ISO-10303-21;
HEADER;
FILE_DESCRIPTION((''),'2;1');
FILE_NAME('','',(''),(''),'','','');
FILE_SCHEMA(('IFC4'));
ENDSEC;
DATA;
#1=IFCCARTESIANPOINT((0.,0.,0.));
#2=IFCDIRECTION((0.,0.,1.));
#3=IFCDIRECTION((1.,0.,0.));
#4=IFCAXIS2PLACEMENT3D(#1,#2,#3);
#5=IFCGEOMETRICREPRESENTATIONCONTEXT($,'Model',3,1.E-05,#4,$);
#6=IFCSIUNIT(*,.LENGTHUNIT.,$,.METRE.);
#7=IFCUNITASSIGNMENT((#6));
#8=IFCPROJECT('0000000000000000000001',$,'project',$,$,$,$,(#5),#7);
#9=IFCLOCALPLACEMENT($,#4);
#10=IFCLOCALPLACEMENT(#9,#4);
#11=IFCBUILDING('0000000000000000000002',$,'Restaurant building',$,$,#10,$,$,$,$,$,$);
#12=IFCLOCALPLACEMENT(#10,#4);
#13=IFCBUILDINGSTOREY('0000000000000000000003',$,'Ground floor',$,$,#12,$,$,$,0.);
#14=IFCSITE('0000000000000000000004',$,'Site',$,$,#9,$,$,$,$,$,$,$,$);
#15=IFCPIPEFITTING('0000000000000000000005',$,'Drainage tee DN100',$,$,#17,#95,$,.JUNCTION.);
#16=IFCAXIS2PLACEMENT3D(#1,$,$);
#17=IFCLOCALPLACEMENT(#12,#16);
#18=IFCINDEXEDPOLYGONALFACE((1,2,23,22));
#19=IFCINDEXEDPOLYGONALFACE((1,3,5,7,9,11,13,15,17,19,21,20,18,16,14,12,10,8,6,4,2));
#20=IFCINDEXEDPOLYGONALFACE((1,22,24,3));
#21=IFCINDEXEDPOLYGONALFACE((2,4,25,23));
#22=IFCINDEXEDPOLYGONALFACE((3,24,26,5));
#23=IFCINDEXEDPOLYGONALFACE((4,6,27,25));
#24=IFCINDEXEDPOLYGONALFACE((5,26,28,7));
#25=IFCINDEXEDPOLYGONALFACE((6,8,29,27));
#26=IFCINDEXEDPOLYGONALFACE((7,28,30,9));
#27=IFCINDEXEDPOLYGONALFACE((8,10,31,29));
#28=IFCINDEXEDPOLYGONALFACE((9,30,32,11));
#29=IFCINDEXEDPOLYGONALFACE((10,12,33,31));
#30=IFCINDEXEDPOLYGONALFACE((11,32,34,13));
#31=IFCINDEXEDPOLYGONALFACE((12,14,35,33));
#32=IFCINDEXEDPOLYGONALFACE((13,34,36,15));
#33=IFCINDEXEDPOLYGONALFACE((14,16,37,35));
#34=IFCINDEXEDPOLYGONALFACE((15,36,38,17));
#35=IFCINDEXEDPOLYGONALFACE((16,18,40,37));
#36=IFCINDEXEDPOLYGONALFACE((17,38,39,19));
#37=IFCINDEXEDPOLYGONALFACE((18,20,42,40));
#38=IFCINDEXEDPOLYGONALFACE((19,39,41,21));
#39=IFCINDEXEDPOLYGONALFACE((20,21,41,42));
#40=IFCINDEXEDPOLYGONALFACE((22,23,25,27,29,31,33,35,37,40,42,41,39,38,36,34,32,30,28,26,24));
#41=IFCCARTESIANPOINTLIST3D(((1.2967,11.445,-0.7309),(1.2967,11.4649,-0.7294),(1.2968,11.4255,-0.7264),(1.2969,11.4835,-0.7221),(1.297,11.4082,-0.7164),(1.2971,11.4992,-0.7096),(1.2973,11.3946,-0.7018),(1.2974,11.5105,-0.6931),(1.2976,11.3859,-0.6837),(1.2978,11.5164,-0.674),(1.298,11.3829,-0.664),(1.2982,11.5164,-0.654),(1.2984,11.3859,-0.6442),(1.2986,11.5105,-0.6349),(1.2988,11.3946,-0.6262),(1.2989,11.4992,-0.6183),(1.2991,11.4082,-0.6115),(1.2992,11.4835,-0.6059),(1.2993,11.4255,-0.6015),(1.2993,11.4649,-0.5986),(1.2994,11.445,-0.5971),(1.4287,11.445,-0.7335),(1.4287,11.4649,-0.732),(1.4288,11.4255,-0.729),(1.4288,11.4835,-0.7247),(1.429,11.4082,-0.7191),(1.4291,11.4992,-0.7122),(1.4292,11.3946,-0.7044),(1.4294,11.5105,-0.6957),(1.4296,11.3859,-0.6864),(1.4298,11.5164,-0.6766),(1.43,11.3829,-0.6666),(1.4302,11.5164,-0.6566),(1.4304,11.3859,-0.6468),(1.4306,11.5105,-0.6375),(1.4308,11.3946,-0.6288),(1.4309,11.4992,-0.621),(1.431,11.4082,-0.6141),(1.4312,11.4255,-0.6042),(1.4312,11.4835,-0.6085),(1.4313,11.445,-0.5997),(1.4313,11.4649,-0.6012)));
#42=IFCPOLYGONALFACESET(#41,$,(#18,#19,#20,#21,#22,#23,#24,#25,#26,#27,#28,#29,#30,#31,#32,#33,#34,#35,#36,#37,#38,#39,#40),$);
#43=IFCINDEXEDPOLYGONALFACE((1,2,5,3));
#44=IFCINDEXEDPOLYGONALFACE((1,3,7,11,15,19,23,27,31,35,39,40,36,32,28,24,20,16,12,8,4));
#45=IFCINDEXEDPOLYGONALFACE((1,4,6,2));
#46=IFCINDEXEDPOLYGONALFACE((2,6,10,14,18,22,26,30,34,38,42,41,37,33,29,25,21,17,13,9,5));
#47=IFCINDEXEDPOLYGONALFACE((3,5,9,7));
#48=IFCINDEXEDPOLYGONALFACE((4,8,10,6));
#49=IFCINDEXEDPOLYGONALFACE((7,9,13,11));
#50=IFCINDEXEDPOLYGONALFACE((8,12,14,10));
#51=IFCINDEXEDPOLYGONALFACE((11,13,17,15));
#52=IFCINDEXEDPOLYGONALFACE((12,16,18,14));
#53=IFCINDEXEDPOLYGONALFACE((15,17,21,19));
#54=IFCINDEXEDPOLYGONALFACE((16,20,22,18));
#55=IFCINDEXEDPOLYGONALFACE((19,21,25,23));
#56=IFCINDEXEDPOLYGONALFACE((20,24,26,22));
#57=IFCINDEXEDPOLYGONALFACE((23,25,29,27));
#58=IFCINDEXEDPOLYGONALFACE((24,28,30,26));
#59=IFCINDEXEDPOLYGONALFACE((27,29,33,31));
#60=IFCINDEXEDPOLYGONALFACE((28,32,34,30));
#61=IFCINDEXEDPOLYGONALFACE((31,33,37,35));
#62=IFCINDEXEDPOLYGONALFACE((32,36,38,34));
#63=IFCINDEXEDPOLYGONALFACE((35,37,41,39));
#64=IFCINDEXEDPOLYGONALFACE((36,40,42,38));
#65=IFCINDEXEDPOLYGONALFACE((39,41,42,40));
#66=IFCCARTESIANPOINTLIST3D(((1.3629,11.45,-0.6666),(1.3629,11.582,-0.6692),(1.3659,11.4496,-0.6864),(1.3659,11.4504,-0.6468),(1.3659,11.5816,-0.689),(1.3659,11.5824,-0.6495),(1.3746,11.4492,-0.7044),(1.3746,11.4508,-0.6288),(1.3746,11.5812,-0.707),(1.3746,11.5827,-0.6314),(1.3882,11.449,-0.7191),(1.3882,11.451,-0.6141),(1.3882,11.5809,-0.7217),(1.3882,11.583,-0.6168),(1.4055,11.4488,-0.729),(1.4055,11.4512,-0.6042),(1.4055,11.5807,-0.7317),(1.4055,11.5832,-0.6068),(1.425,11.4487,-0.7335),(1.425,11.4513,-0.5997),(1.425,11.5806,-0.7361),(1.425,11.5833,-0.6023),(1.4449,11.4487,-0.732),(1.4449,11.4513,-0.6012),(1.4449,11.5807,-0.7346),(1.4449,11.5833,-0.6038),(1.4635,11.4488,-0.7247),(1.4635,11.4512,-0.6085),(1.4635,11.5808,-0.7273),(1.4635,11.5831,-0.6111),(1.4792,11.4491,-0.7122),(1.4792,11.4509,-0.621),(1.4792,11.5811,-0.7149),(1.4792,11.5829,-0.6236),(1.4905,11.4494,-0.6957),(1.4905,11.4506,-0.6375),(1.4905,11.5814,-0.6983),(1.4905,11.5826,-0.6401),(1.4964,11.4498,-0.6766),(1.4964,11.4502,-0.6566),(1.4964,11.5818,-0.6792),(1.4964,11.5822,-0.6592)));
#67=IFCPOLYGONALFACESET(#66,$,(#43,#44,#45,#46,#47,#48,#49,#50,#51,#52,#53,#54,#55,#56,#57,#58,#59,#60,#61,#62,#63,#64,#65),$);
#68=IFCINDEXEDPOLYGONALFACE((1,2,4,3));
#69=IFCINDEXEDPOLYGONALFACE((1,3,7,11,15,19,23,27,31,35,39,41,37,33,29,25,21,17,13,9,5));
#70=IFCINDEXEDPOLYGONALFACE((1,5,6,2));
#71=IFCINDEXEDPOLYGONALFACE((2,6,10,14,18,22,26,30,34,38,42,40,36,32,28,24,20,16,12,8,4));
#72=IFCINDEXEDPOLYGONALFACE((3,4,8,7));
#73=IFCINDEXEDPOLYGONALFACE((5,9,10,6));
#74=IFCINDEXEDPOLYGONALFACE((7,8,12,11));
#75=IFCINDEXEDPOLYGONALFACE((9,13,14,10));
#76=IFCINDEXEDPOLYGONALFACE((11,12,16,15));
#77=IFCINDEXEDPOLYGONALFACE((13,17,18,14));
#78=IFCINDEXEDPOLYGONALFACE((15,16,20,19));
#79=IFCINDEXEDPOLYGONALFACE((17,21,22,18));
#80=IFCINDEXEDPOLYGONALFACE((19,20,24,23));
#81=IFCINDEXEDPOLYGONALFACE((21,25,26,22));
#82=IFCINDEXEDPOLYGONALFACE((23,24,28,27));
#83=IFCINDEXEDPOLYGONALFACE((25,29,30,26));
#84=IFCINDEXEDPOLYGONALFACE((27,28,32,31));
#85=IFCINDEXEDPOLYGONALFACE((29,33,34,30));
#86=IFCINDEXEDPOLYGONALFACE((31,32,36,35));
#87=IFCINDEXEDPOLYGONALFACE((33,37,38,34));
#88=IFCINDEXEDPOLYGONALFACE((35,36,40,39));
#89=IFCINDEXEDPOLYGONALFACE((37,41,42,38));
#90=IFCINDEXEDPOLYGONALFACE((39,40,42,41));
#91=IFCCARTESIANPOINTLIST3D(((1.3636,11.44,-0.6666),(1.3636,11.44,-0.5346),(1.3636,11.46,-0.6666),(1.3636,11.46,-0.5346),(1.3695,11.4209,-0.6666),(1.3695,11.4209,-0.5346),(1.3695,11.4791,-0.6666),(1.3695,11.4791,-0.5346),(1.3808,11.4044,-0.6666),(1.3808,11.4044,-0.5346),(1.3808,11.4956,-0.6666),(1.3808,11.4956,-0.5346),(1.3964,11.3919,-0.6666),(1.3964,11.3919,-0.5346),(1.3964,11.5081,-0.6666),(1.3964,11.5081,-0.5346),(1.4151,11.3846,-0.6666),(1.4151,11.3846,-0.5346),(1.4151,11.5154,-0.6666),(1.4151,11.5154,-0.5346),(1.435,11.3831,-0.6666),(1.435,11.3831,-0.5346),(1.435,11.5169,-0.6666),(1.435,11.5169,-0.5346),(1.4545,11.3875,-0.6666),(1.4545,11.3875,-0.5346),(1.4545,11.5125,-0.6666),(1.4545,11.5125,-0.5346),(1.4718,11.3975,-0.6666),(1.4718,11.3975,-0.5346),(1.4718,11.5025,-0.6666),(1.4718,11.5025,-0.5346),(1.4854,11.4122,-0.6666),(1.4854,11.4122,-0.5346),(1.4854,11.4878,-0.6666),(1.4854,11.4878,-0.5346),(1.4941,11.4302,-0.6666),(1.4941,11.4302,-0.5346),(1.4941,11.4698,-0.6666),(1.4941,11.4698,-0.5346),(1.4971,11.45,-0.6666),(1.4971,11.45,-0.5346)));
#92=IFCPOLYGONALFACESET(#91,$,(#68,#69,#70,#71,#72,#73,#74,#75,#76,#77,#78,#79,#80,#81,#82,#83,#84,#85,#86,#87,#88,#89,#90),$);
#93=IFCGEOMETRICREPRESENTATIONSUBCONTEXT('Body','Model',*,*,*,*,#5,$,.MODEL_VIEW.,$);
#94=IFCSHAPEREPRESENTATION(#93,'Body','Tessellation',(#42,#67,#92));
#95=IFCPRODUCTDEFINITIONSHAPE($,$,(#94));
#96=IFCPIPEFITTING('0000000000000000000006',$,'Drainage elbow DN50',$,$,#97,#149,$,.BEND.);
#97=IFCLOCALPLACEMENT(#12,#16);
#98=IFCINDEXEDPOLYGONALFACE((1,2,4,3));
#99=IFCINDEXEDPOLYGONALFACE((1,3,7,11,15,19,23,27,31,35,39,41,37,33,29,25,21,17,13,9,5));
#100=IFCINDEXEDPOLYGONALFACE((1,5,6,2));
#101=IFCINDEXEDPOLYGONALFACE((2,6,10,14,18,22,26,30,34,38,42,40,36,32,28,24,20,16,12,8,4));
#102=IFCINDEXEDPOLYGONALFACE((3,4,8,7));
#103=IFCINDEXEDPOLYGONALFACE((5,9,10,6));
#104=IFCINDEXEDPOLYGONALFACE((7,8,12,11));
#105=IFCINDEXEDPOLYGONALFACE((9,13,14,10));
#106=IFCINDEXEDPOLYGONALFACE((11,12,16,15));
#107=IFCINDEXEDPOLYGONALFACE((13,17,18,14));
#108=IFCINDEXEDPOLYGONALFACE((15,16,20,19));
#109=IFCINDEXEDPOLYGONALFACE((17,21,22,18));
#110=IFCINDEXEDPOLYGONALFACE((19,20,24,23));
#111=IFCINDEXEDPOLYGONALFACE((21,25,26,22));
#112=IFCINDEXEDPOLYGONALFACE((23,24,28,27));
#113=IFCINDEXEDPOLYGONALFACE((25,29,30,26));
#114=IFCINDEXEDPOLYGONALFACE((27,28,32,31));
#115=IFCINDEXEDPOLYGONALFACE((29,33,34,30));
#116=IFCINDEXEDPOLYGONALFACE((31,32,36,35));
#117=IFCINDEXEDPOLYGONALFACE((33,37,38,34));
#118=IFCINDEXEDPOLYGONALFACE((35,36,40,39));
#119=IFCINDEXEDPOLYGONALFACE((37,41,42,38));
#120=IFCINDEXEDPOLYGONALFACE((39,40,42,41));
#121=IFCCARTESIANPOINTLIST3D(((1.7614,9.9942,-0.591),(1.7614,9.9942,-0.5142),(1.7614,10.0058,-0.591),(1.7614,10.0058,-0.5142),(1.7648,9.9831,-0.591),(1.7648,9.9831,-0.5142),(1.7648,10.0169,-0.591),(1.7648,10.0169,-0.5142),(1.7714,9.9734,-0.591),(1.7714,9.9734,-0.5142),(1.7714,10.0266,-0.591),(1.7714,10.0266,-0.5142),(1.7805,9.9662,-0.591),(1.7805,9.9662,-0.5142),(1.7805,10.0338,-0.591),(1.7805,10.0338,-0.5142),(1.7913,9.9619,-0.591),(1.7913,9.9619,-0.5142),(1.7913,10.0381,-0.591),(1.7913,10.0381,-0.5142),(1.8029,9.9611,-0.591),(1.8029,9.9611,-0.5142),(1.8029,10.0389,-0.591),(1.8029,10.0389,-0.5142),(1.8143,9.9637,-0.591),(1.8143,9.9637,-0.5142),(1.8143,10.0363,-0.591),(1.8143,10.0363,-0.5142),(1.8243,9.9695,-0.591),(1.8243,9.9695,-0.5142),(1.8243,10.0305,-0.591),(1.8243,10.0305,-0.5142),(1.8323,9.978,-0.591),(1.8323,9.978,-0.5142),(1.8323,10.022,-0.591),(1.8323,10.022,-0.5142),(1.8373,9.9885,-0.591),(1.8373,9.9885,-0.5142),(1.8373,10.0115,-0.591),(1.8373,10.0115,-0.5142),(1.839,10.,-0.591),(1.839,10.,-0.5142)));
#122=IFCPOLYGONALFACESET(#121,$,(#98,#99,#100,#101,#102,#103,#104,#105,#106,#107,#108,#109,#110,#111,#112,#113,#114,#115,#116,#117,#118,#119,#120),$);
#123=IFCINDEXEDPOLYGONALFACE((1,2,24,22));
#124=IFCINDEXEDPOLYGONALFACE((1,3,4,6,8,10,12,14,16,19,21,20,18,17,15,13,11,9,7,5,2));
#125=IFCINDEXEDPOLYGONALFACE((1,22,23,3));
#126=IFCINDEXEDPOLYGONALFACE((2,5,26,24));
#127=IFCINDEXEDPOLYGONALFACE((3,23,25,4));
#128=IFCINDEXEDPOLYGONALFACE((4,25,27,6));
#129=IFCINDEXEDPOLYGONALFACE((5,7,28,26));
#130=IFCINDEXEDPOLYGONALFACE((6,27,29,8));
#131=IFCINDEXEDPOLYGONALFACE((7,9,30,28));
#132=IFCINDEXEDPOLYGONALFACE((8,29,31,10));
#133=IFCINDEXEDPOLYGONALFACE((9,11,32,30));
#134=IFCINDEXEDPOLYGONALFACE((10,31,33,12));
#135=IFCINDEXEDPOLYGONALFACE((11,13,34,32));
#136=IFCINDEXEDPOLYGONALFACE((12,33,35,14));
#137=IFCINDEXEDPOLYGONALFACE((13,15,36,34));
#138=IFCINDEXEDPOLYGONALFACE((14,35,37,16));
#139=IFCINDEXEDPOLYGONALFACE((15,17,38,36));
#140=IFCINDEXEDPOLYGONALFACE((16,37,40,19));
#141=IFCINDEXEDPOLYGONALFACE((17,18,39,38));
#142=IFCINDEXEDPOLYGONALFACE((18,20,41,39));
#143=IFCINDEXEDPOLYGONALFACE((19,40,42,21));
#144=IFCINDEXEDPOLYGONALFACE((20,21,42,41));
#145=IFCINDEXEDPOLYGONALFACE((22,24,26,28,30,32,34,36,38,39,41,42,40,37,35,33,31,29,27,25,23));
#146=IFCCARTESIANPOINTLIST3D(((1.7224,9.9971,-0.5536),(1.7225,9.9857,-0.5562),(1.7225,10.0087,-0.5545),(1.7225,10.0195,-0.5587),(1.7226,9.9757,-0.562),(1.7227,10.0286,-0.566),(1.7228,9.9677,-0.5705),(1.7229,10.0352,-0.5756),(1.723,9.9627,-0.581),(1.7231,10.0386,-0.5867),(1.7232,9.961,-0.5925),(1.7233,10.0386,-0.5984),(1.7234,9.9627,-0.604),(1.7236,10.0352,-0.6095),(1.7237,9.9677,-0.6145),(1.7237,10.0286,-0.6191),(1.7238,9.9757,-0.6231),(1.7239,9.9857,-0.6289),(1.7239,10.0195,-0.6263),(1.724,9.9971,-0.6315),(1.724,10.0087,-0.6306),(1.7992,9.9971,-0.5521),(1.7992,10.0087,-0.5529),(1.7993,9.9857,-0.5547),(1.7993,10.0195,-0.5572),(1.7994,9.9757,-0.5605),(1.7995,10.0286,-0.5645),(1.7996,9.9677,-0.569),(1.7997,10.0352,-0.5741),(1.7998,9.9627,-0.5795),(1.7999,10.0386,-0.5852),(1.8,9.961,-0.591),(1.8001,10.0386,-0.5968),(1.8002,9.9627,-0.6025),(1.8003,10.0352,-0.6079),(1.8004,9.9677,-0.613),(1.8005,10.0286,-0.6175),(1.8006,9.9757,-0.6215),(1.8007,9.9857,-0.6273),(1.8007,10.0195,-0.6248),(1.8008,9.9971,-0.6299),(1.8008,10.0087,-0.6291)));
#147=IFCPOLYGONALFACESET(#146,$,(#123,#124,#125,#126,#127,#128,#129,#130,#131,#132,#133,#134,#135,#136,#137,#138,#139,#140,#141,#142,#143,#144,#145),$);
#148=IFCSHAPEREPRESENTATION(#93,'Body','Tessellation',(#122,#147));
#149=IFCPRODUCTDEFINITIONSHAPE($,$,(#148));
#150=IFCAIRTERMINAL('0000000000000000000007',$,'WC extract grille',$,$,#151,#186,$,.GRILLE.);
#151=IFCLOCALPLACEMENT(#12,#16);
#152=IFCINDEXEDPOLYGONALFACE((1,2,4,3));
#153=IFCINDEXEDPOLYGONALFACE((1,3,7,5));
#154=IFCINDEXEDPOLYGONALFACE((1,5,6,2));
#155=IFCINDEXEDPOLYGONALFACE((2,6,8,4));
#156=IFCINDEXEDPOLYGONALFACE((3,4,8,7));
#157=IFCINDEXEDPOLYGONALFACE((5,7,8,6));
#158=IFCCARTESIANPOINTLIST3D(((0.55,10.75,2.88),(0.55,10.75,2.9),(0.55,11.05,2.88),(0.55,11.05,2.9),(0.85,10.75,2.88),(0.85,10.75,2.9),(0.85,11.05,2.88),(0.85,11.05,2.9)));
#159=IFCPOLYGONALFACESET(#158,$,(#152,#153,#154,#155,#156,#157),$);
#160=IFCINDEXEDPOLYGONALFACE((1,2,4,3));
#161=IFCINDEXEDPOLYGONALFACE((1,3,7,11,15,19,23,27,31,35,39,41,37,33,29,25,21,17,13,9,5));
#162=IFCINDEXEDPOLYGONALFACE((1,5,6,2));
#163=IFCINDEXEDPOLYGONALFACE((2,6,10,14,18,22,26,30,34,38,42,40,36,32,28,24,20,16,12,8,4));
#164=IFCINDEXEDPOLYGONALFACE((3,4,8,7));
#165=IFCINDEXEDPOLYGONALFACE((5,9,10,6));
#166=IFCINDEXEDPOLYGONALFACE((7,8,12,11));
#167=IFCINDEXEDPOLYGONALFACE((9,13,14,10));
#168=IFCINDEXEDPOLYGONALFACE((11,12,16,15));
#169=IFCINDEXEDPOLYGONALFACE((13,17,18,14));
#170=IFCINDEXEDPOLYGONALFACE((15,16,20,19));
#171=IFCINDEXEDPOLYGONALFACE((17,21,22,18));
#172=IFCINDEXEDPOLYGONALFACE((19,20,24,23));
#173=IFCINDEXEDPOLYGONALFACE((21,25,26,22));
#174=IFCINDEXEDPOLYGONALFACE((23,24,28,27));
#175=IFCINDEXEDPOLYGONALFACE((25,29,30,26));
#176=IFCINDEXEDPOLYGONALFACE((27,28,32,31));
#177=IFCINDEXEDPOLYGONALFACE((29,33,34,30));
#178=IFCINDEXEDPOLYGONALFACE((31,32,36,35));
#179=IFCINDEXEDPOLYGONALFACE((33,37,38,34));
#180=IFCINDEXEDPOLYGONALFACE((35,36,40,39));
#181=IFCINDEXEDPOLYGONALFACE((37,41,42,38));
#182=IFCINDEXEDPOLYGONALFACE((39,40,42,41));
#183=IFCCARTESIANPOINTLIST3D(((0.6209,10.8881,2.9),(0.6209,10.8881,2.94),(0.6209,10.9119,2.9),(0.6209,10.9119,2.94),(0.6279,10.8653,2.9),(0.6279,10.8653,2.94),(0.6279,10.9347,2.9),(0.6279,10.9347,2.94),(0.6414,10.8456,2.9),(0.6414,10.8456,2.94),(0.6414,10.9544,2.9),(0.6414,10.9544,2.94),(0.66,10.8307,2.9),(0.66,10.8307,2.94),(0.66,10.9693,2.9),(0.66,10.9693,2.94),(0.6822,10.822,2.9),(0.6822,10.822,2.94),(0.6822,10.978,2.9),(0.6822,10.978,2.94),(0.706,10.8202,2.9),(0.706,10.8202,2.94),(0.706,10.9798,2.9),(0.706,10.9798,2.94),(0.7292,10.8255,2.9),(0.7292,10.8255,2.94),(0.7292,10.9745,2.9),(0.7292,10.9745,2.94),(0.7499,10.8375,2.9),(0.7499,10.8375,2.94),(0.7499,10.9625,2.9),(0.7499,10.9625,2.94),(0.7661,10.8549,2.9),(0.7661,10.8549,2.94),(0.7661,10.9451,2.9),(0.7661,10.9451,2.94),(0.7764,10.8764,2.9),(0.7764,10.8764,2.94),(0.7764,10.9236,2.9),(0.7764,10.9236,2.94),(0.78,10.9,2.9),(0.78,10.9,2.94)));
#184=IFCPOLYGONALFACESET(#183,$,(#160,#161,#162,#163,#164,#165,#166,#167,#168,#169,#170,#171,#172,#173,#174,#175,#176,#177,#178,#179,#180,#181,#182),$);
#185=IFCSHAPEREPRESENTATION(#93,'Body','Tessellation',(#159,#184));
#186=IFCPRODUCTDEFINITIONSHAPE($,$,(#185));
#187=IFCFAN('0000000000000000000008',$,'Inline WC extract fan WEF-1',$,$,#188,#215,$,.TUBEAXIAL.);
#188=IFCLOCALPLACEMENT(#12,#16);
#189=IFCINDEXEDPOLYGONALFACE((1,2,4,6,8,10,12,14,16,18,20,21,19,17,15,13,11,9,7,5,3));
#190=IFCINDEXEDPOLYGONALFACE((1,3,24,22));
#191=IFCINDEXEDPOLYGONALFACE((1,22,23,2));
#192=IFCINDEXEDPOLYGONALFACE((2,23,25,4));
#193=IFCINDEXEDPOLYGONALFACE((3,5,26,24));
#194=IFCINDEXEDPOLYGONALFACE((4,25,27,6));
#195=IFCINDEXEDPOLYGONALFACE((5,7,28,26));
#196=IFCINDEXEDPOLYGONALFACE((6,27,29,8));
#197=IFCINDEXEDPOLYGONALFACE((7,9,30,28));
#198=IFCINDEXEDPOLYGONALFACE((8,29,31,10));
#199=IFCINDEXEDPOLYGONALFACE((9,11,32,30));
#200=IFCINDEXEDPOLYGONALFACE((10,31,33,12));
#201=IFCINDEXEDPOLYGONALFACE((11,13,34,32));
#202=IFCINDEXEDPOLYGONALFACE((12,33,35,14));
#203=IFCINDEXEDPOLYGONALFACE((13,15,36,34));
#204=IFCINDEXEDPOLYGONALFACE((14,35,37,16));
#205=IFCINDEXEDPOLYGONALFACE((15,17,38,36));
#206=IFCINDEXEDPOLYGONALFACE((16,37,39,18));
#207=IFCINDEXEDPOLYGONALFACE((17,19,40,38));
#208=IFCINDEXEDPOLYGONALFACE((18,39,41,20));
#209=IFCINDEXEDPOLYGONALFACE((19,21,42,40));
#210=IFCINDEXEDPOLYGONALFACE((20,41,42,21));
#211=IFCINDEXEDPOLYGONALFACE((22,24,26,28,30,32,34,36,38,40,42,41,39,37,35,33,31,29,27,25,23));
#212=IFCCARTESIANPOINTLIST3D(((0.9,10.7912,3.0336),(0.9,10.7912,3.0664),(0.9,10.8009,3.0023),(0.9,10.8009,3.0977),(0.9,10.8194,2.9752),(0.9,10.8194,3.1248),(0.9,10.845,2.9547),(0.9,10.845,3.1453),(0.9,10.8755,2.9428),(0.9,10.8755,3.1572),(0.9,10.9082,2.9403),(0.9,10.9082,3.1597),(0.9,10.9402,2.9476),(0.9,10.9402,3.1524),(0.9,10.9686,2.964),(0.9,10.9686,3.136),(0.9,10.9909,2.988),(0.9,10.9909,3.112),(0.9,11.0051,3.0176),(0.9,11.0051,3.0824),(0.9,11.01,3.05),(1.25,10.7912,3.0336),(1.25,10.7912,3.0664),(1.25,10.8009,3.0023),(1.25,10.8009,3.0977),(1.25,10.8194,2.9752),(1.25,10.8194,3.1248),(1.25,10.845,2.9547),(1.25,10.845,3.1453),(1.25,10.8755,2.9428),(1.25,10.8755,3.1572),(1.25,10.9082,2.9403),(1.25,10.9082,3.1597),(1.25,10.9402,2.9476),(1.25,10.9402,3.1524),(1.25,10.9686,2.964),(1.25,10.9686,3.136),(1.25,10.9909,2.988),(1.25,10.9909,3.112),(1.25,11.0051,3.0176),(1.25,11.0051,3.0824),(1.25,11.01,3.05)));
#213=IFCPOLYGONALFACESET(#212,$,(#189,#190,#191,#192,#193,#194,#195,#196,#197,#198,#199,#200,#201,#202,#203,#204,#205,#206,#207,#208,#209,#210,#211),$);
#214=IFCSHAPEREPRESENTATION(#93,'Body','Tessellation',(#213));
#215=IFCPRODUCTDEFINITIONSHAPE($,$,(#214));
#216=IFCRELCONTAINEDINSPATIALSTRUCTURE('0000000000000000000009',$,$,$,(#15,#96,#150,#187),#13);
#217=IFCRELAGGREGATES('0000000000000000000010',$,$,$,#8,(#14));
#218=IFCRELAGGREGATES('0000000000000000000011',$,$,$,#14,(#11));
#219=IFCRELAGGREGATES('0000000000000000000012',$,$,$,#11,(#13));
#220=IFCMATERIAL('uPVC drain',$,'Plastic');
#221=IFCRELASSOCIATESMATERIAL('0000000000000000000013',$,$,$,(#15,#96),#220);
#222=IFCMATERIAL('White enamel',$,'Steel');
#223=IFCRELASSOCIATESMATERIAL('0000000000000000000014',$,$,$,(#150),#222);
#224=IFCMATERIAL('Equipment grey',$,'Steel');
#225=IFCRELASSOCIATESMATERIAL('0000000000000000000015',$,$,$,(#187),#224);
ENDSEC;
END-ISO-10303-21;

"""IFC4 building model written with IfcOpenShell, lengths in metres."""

from ifc_helpers import new_model, si_unit, frame, origin, origin_with_axes, origin_2d, place, context, subcontext, project, spatial, rectangle, circle, extrude, material, element, save


model = new_model("IFC4")

# Units and contexts
model_context = context("Model", 3, precision=1e-05, world=origin_with_axes())
body_context = subcontext(model_context, "Body", "Model", "MODEL_VIEW")
ifc_project = project(units=[si_unit("LENGTHUNIT", "METRE")], contexts=[model_context])

# Site, building, storey
site_placement = place(None, origin_with_axes())
site = spatial("IfcSite", under=ifc_project, at=site_placement, Name="Site")
building_placement = place(site_placement, origin_with_axes())
building = spatial("IfcBuilding", under=site, at=building_placement, Name="Restaurant building")
storey_placement = place(building_placement, origin_with_axes())
storey = spatial("IfcBuildingStorey", under=building, at=storey_placement, Name="Ground floor", Elevation=0.0)

# Shared definitions
ifc_material_1 = material(Name="uPVC drain", Category="Plastic")

# Pipe fittings
pipe_fitting_1_placement = place(storey_placement, frame((1.43, 11.45, -0.6666)))
element("IfcPipeFitting", 1, at=pipe_fitting_1_placement, inside=storey, material=ifc_material_1, Name="Drainage tee DN100", PredefinedType="JUNCTION", context=body_context, shape_type="SweptSolid", body=[
    extrude(circle(Radius=0.0671, at=origin_2d()), frame((0.0, 0.0, 0.0), z_axis=(-0.9998, 0.0, 0.019996), x_axis=(0.0, -1.0, 0.0)), (0.0, 0.0, 1.0), 0.132),
    extrude(circle(Radius=0.0671, at=origin_2d()), frame((0.0, 0.0, 0.0), z_axis=(0.0, 0.9998, -0.019996), x_axis=(-1.0, 0.0, 0.0)), (0.0, 0.0, 1.0), 0.132),
    extrude(circle(Radius=0.0671, at=origin_2d()), origin(), (0.0, 0.0, 1.0), 0.132),
])
pipe_fitting_2_placement = place(storey_placement, frame((1.8, 10.0, -0.591)))
element("IfcPipeFitting", 2, at=pipe_fitting_2_placement, inside=storey, material=ifc_material_1, Name="Drainage elbow DN50", PredefinedType="BEND", context=body_context, shape_type="SweptSolid", body=[
    extrude(circle(Radius=0.039, at=origin_2d()), origin(), (0.0, 0.0, 1.0), 0.0768),
    extrude(circle(Radius=0.039, at=origin_2d()), frame((0.0, 0.0, 0.0), z_axis=(-0.9998, 0.0, -0.019996), x_axis=(0.0, -1.0, 0.0)), (0.0, 0.0, 1.0), 0.0768),
])

# Air terminal
ifc_material_2 = material(Name="White enamel", Category="Steel")
air_terminal_placement = place(storey_placement, frame((0.7, 10.9, 0.0)))
element("IfcAirTerminal", 3, at=air_terminal_placement, inside=storey, material=ifc_material_2, Name="WC extract grille", PredefinedType="GRILLE", context=body_context, shape_type="SweptSolid", body=[
    extrude(rectangle(XDim=0.3, YDim=0.3, at=origin_2d()), frame((0.0, 0.0, 2.88)), (0.0, 0.0, 1.0), 0.02),
    extrude(circle(Radius=0.08, at=origin_2d()), frame((0.0, 0.0, 2.9)), (0.0, 0.0, 1.0), 0.04),
])

# Fan
ifc_material_3 = material(Name="Equipment grey", Category="Steel")
fan_placement = place(storey_placement, frame((0.9, 10.9, 0.0)))
element("IfcFan", 4, at=fan_placement, inside=storey, material=ifc_material_3, Name="Inline WC extract fan WEF-1", PredefinedType="TUBEAXIAL", context=body_context, shape_type="SweptSolid", body=[
    extrude(circle(Radius=0.11, at=origin_2d()), frame((0.0, 0.0, 3.05), z_axis=(1.0, 0.0, 0.0), x_axis=(0.0, 1.0, 0.0)), (0.0, 0.0, 1.0), 0.35),
])

save(model, "model.ifc")
